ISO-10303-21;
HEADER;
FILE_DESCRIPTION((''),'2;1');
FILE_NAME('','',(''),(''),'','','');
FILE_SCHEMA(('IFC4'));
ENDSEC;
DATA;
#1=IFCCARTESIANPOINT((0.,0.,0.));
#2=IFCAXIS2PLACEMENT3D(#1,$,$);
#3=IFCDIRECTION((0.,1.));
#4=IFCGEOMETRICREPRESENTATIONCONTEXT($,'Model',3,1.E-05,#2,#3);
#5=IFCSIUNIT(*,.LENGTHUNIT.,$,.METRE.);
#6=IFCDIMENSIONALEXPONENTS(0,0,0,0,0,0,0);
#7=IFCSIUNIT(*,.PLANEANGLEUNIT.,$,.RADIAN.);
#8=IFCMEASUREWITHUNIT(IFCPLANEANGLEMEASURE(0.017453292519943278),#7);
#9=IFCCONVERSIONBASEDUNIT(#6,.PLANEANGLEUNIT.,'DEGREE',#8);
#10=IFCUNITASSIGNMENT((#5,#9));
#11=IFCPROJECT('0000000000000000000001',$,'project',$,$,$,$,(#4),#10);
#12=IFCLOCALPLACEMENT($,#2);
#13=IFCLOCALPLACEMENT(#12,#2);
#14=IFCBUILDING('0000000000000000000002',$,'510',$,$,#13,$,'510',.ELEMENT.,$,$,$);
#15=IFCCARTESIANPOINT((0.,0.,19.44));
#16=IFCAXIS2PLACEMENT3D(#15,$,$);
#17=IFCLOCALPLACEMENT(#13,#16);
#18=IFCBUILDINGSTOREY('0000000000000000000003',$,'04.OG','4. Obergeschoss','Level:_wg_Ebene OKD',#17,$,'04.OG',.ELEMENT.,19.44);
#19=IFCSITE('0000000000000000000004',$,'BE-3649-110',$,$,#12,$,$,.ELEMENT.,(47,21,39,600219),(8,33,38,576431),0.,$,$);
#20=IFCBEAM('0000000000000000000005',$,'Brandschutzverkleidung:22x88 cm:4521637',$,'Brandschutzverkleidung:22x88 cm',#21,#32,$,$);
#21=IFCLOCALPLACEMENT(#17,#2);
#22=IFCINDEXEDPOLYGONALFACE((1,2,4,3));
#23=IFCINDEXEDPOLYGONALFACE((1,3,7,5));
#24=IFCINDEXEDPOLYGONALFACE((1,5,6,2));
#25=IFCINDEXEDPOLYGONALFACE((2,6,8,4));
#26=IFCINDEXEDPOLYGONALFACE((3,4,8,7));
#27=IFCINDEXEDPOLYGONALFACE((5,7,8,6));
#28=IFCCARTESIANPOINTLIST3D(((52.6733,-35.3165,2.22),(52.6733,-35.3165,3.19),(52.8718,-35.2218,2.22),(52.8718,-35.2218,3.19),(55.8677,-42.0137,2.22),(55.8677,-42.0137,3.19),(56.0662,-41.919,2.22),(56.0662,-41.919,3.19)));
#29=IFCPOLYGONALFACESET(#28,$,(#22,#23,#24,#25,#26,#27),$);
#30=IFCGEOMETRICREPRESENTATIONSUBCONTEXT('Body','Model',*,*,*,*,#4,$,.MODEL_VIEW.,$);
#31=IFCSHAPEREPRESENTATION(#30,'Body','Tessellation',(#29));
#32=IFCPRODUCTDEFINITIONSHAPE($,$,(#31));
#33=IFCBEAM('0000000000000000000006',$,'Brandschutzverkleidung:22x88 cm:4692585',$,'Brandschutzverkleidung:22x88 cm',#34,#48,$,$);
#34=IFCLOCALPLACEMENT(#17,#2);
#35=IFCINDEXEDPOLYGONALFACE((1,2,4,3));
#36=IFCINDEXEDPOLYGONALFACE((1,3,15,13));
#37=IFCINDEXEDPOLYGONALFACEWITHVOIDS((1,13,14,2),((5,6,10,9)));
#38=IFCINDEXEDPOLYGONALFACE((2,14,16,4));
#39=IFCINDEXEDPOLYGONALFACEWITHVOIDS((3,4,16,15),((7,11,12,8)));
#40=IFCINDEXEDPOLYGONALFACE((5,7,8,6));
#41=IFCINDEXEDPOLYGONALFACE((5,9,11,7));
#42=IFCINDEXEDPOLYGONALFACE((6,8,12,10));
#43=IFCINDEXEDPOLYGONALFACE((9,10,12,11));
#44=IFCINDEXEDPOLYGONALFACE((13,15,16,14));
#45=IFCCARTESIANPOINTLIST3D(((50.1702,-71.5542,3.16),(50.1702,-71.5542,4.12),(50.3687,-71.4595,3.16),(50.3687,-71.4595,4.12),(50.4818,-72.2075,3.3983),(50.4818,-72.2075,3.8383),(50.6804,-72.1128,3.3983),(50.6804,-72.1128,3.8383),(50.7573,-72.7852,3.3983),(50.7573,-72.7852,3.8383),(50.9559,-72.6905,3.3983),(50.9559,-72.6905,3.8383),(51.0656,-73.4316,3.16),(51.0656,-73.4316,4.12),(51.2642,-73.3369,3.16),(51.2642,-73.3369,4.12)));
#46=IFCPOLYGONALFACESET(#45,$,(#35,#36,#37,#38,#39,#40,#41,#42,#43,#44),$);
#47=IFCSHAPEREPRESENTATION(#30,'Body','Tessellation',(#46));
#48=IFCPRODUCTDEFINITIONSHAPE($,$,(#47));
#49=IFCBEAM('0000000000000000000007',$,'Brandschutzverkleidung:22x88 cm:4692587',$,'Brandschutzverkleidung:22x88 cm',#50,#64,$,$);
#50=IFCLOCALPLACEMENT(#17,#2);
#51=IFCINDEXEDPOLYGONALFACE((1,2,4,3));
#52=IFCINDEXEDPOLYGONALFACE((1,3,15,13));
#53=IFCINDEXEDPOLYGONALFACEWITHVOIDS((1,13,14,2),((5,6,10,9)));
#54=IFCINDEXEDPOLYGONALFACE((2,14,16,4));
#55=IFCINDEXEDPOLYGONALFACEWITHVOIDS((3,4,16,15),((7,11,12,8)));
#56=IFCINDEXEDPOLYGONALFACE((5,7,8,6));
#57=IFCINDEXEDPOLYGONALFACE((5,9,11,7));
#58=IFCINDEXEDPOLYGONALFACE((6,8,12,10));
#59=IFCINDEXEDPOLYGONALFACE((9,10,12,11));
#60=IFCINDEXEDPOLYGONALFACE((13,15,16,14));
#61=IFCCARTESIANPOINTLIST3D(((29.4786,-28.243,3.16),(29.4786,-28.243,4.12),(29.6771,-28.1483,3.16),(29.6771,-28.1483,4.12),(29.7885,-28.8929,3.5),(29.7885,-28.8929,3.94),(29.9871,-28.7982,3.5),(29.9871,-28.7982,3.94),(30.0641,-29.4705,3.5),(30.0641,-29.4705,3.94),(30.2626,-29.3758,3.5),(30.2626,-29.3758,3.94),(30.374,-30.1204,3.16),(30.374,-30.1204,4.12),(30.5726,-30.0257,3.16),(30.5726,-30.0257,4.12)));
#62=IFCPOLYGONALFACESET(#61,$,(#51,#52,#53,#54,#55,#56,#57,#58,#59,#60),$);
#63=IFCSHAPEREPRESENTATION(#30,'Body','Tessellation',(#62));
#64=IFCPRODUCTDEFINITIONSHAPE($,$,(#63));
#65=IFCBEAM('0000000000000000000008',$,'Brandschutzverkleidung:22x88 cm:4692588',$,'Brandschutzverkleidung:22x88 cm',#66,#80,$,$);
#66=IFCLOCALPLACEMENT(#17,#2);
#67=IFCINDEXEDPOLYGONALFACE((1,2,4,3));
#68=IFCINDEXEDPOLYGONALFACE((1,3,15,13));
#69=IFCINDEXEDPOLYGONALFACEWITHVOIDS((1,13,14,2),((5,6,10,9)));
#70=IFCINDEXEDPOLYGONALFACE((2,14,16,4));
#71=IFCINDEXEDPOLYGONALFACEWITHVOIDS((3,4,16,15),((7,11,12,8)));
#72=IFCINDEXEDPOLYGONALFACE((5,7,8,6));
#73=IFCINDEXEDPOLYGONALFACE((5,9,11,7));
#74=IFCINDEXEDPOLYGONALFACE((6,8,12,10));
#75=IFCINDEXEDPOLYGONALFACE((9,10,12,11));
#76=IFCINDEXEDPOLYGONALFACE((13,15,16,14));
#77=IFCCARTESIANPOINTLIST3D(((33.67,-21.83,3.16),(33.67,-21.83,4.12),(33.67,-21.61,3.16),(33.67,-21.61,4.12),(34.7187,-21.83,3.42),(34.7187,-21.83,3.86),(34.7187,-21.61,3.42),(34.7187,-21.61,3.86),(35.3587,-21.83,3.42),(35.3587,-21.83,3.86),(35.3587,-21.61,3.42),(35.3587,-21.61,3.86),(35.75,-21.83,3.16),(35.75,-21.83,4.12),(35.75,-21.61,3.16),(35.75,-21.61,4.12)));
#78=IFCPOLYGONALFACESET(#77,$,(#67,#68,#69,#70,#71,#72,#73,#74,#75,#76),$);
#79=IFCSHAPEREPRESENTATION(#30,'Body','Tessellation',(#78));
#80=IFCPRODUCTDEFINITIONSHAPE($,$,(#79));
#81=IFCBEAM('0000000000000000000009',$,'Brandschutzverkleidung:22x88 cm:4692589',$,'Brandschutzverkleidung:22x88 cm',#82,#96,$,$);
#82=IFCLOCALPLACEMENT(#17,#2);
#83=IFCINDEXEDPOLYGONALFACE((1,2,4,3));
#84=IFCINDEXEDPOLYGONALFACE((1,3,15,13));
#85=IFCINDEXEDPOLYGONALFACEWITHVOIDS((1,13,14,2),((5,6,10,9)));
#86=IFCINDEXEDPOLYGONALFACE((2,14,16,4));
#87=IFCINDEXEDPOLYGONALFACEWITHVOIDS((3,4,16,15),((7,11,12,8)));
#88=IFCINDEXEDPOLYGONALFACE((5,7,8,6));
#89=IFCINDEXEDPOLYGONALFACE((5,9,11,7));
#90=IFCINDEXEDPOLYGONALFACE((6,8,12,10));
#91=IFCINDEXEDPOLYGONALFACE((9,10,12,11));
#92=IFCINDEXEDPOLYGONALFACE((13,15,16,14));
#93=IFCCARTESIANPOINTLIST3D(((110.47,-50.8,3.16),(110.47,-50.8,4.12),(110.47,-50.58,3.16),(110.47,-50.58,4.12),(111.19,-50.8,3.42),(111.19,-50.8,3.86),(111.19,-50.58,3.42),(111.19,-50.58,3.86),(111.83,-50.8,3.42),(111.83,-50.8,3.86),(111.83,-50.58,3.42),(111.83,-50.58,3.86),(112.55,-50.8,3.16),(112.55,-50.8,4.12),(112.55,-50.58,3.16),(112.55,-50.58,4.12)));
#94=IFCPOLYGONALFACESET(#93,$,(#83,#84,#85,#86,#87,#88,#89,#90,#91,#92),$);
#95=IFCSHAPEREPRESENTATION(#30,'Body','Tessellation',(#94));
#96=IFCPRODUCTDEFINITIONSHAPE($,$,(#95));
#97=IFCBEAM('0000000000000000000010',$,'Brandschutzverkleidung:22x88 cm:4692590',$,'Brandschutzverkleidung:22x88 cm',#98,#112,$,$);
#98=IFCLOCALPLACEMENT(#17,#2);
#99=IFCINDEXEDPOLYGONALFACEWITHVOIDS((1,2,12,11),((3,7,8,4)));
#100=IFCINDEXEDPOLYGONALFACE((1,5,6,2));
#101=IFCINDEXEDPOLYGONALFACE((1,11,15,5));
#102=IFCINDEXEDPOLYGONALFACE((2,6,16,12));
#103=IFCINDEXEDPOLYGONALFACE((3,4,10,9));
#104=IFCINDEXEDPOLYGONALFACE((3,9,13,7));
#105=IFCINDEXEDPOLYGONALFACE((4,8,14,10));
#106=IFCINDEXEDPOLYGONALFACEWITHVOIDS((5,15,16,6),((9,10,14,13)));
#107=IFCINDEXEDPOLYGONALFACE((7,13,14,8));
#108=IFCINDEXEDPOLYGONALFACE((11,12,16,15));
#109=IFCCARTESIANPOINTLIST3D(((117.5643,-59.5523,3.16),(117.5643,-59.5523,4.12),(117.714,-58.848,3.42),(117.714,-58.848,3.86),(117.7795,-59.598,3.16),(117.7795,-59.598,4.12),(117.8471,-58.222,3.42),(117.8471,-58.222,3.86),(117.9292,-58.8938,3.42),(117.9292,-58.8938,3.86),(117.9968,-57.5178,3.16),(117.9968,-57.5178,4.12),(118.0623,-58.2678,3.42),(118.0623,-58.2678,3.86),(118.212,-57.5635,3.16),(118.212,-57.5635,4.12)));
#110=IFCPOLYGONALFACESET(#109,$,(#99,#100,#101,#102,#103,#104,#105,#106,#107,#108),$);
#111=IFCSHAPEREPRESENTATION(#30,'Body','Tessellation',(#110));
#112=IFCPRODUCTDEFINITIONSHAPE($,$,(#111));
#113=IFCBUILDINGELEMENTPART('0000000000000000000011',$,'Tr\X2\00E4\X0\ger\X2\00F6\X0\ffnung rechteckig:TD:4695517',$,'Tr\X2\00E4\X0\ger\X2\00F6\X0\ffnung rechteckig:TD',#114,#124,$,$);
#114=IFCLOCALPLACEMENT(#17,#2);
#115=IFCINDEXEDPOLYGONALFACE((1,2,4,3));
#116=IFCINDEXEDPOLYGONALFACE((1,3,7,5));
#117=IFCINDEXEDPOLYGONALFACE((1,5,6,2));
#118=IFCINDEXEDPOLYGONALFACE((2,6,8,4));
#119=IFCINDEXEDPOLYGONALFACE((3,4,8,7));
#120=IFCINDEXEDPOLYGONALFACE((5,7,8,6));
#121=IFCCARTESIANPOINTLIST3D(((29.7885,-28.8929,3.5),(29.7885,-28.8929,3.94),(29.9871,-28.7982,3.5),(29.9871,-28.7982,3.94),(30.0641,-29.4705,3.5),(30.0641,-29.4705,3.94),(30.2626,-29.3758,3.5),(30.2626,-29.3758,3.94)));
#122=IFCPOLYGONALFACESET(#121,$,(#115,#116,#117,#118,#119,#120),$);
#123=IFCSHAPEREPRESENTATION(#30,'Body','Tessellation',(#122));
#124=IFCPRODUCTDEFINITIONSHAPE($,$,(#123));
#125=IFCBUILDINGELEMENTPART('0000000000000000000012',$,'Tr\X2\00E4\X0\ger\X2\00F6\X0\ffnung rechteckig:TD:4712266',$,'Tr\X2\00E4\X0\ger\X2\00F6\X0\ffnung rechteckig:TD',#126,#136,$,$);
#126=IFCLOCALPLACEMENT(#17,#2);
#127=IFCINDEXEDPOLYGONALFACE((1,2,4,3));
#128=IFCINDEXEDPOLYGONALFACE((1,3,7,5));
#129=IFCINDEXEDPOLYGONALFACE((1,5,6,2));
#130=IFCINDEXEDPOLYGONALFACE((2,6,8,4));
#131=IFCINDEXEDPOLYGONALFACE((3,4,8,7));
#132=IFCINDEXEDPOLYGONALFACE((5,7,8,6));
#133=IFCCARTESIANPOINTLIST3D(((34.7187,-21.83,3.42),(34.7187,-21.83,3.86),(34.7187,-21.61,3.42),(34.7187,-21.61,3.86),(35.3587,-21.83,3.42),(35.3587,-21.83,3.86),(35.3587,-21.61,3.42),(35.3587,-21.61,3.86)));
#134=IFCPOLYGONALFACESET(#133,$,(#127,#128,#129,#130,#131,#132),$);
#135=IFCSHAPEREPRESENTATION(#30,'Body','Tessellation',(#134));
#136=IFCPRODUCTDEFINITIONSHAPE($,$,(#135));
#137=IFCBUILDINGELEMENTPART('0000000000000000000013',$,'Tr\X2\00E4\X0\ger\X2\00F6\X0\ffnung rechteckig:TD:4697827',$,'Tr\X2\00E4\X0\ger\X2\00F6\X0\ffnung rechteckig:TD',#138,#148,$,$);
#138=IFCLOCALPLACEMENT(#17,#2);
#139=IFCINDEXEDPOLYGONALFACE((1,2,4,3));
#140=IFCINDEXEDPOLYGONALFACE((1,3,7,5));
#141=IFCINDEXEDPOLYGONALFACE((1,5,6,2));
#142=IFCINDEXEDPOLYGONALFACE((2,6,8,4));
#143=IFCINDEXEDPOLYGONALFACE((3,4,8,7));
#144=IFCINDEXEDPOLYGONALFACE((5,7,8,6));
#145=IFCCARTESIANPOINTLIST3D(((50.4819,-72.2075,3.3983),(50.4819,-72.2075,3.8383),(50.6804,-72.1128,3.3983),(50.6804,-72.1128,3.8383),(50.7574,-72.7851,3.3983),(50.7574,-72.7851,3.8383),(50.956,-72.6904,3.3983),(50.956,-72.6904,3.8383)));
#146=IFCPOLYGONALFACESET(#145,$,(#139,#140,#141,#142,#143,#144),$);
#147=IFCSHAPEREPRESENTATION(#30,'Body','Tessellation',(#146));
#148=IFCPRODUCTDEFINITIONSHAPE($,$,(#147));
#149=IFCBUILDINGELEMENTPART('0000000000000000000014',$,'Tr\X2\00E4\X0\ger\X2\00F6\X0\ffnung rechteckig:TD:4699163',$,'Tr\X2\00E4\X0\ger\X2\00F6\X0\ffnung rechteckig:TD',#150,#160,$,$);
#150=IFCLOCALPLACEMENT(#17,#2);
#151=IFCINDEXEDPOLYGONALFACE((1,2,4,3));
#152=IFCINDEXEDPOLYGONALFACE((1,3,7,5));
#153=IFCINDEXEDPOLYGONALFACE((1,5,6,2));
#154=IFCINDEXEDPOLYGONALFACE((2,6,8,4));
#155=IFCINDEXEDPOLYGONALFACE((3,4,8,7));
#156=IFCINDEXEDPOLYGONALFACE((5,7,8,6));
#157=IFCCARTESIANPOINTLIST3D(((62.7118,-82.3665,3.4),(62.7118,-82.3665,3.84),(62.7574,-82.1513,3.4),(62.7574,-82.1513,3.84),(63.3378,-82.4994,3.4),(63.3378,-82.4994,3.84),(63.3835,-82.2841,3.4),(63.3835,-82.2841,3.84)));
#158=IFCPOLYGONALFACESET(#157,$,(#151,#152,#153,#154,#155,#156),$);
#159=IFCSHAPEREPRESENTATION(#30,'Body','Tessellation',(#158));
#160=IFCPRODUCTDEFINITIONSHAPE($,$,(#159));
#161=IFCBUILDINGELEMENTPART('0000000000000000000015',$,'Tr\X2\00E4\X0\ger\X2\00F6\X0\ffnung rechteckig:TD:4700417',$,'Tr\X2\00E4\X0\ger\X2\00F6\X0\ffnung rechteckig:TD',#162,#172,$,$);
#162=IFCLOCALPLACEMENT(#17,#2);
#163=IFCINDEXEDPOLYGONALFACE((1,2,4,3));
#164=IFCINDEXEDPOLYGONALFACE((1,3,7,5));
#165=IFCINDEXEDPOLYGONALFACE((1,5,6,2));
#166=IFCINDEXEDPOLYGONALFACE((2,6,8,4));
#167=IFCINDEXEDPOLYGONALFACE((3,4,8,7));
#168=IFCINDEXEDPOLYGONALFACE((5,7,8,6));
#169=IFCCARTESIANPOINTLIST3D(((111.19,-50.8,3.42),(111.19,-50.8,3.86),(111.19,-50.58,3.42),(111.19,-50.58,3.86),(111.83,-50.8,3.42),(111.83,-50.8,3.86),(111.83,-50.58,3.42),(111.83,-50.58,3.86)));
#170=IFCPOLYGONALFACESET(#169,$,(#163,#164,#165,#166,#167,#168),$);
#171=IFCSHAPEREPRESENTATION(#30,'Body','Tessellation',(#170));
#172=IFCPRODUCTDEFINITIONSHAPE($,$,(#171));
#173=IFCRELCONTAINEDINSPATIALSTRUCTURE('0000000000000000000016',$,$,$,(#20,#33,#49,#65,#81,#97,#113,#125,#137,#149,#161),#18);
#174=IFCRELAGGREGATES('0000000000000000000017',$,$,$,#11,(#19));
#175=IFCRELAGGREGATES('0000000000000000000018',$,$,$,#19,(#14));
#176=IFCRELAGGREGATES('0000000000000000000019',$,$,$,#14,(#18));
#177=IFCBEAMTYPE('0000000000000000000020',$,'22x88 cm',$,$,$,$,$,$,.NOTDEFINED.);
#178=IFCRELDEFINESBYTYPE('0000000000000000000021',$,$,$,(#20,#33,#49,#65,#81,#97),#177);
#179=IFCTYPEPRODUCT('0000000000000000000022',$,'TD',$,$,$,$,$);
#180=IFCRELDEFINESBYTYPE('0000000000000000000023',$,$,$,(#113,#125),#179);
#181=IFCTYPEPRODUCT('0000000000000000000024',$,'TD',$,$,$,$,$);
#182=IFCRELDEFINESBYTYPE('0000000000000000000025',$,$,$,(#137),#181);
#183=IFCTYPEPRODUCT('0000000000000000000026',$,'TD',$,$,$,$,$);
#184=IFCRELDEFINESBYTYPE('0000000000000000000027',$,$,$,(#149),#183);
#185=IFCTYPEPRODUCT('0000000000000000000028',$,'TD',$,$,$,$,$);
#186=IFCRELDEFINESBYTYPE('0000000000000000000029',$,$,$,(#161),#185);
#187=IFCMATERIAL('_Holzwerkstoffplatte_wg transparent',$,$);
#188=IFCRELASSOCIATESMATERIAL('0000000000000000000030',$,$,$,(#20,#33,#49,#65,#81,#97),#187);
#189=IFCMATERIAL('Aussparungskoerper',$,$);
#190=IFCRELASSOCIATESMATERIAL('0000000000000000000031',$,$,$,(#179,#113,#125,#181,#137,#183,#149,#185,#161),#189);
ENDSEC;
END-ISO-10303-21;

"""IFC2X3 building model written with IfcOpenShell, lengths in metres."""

from ifc_helpers import new_model, entity, si_unit, converted_unit, direction, frame, frame_2d, origin, origin_2d_with_axis, place, context, subcontext, project, spatial, polyline, rectangle, outline, extrude, source, transform, mapped, material, type_object, type_shapes, element, save


model = new_model("IFC2X3")

# Units and contexts
model_context = context("Model", 3, precision=1e-05, world=origin(), true_north=direction((0.0, 1.0)))
body_context = subcontext(model_context, "Body", "Model", "MODEL_VIEW")
ifc_project = project(units=[si_unit("LENGTHUNIT", "METRE"), converted_unit("PLANEANGLEUNIT", "DEGREE", entity("IfcPlaneAngleMeasure", 0.017453292519943278), si_unit("PLANEANGLEUNIT", "RADIAN"), dimensions=[0, 0, 0, 0, 0, 0, 0])], contexts=[model_context])

# Site, building, storey
site_placement = place(None, origin())
site = spatial("IfcSite", under=ifc_project, at=site_placement, Name="BE-3649-110", CompositionType="ELEMENT", RefLatitude=(47, 21, 39, 600219), RefLongitude=(8, 33, 38, 576431), RefElevation=0.0)
building_placement = place(site_placement, origin())
building = spatial("IfcBuilding", under=site, at=building_placement, Name="510", LongName="510", CompositionType="ELEMENT")
storey_placement = place(building_placement, frame((0.0, 0.0, 19.44)))
storey = spatial("IfcBuildingStorey", under=building, at=storey_placement, Name="04.OG", Description="4. Obergeschoss", ObjectType="Level:_wg_Ebene OKD", LongName="04.OG", CompositionType="ELEMENT", Elevation=19.44)

# Beams
ifc_material_1 = material(Name="_Holzwerkstoffplatte_wg transparent")
beam_type_1 = type_object("IfcBeamType", Name="22x88 cm", PredefinedType="NOTDEFINED")
beam_1_placement = place(storey_placement, frame((0.0, 0.0, 2.705)))
element("IfcBeam", 1, at=beam_1_placement, inside=storey, type_object=beam_type_1, material=ifc_material_1, Name="Brandschutzverkleidung:22x88 cm:4521637", ObjectType="Brandschutzverkleidung:22x88 cm", context=body_context, shape_type="SweptSolid", body=[
    extrude(rectangle(XDim=0.97, YDim=0.22, at=frame_2d((0.0, 0.1517), x_axis=(0.0, 1.0))), frame((55.967, -41.9663, 0.1517), z_axis=(-0.430511, 0.902585, 0.0), x_axis=(0.902585, 0.430511, 0.0)), (0.0, 0.0, 1.0), 7.42),
])
beam_2_placement = place(storey_placement, frame((0.0, 0.0, 3.64)))
element("IfcBeam", 2, at=beam_2_placement, inside=storey, type_object=beam_type_1, material=ifc_material_1, Name="Brandschutzverkleidung:22x88 cm:4692585", ObjectType="Brandschutzverkleidung:22x88 cm", context=body_context, shape_type="SweptSolid", body=[
    extrude(outline(polyline([(-1.04, -0.48), (1.04, -0.48), (1.04, 0.48), (-1.04, 0.48), (-1.04, -0.48)]), holes=[polyline([(0.3238, 0.2417), (0.3238, -0.1983), (-0.3162, -0.1983), (-0.3162, 0.2417), (0.3238, 0.2417)])]), frame((50.6179, -72.4929, 0.0), z_axis=(0.902585, 0.430511, 0.0), x_axis=(0.430511, -0.902585, 0.0)), (0.0, 0.0, 1.0), 0.22),
])
beam_3_placement = place(storey_placement, frame((0.0, 0.0, 3.64)))
element("IfcBeam", 3, at=beam_3_placement, inside=storey, type_object=beam_type_1, material=ifc_material_1, Name="Brandschutzverkleidung:22x88 cm:4692587", ObjectType="Brandschutzverkleidung:22x88 cm", context=body_context, shape_type="SweptSolid", body=[
    extrude(outline(polyline([(-1.04, -0.48), (1.04, -0.48), (1.04, 0.48), (-1.04, 0.48), (-1.04, -0.48)]), holes=[polyline([(-0.32, -0.14), (-0.32, 0.3), (0.32, 0.3), (0.32, -0.14), (-0.32, -0.14)])]), frame((29.9263, -29.1817, 0.0), z_axis=(0.902585, 0.430511, 0.0), x_axis=(-0.430511, 0.902585, 0.0)), (0.0, 0.0, 1.0), 0.22),
])
beam_4_placement = place(storey_placement, frame((0.0, 0.0, 3.64)))
element("IfcBeam", 4, at=beam_4_placement, inside=storey, type_object=beam_type_1, material=ifc_material_1, Name="Brandschutzverkleidung:22x88 cm:4692588", ObjectType="Brandschutzverkleidung:22x88 cm", context=body_context, shape_type="SweptSolid", body=[
    extrude(outline(polyline([(-1.04, -0.48), (1.04, -0.48), (1.04, 0.48), (-1.04, 0.48), (-1.04, -0.48)]), holes=[polyline([(0.6487, 0.22), (0.6487, -0.22), (0.0087, -0.22), (0.0087, 0.22), (0.6487, 0.22)])]), frame((34.71, -21.83, 0.0), z_axis=(0.0, 1.0, 0.0), x_axis=(1.0, 0.0, 0.0)), (0.0, 0.0, 1.0), 0.22),
])
beam_5_placement = place(storey_placement, frame((0.0, 0.0, 3.64)))
element("IfcBeam", 5, at=beam_5_placement, inside=storey, type_object=beam_type_1, material=ifc_material_1, Name="Brandschutzverkleidung:22x88 cm:4692589", ObjectType="Brandschutzverkleidung:22x88 cm", context=body_context, shape_type="SweptSolid", body=[
    extrude(outline(polyline([(-1.04, -0.48), (1.04, -0.48), (1.04, 0.48), (-1.04, 0.48), (-1.04, -0.48)]), holes=[polyline([(0.32, 0.22), (0.32, -0.22), (-0.32, -0.22), (-0.32, 0.22), (0.32, 0.22)])]), frame((111.51, -50.8, 0.0), z_axis=(0.0, 1.0, 0.0), x_axis=(1.0, 0.0, 0.0)), (0.0, 0.0, 1.0), 0.22),
])
beam_6_placement = place(storey_placement, frame((0.0, 0.0, 3.64)))
element("IfcBeam", 6, at=beam_6_placement, inside=storey, type_object=beam_type_1, material=ifc_material_1, Name="Brandschutzverkleidung:22x88 cm:4692590", ObjectType="Brandschutzverkleidung:22x88 cm", context=body_context, shape_type="SweptSolid", body=[
    extrude(outline(polyline([(-1.04, -0.48), (1.04, -0.48), (1.04, 0.48), (-1.04, 0.48), (-1.04, -0.48)]), holes=[polyline([(0.32, 0.22), (0.32, -0.22), (-0.32, -0.22), (-0.32, 0.22), (0.32, 0.22)])]), frame((117.7806, -58.535, 0.0), z_axis=(0.978148, -0.207912, 0.0), x_axis=(-0.207912, -0.978148, 0.0)), (0.0, 0.0, 1.0), 0.22),
])

# Building element parts
ifc_material_2 = material(Name="Aussparungskoerper")
type_product_1 = type_object("IfcTypeProduct", Name="TD", material=ifc_material_2)
shared_shape_1 = source(origin(), body_context, "Body", "SweptSolid", [
    extrude(rectangle(XDim=0.44, YDim=0.64, at=origin_2d_with_axis()), frame((0.0, 0.0, -0.22), z_axis=(0.0, 0.0, 1.0), x_axis=(0.0, 1.0, 0.0)), (0.0, 0.0, 1.0), 0.22),
])
type_shapes(type_product_1, [shared_shape_1])
for number, where, z_axis, x_axis, name in (
    (7, (30.1249, -29.087, 3.72), (0.902585, 0.430511, 0.0), (-0.430511, 0.902585, 0.0), "Trägeröffnung rechteckig:TD:4695517"),
    (8, (35.0387, -21.83, 3.64), (0.0, -1.0, 0.0), (1.0, 0.0, 0.0), "Trägeröffnung rechteckig:TD:4712266"),
):
    element("IfcBuildingElementPart", number, at=place(storey_placement, frame(where, z_axis=z_axis, x_axis=x_axis)), inside=storey, type_object=type_product_1, material=ifc_material_2, Name=name, ObjectType="Trägeröffnung rechteckig:TD", context=body_context, shape_type="MappedRepresentation", body=[
        mapped(shared_shape_1, transform((0.0, 0.0, 0.0), scale=1.0)),
    ])
type_product_2 = type_object("IfcTypeProduct", Name="TD", material=ifc_material_2)
shared_shape_2 = source(origin(), body_context, "Body", "SweptSolid", [
    extrude(rectangle(XDim=0.22, YDim=0.64, at=frame_2d((0.0, 0.0), x_axis=(1.0, 0.0))), frame((50.7189, -72.449, -0.44), z_axis=(0.0, 0.0, 1.0), x_axis=(0.902586, 0.43051, 0.0)), (0.0, 0.0, 1.0), 0.44),
])
type_shapes(type_product_2, [shared_shape_2])
building_element_part_1_placement = place(storey_placement, frame((0.0, 0.0, 3.8383)))
element("IfcBuildingElementPart", 9, at=building_element_part_1_placement, inside=storey, type_object=type_product_2, material=ifc_material_2, Name="Trägeröffnung rechteckig:TD:4697827", ObjectType="Trägeröffnung rechteckig:TD", context=body_context, shape_type="MappedRepresentation", body=[
    mapped(shared_shape_2, transform((0.0, 0.0, 0.0), scale=1.0)),
])
type_product_3 = type_object("IfcTypeProduct", Name="TD", material=ifc_material_2)
shared_shape_3 = source(origin(), body_context, "Body", "SweptSolid", [
    extrude(rectangle(XDim=0.44, YDim=0.64, at=origin_2d_with_axis()), frame((0.0, 0.0, -0.22), z_axis=(0.0, 0.0, 1.0), x_axis=(0.0, 1.0, 0.0)), (0.0, 0.0, 1.0), 0.22),
])
type_shapes(type_product_3, [shared_shape_3])
building_element_part_2_placement = place(storey_placement, frame((63.0248, -82.4329, 3.62), z_axis=(-0.207566, -0.978221, 0.0), x_axis=(0.978221, -0.207566, 0.0)))
element("IfcBuildingElementPart", 10, at=building_element_part_2_placement, inside=storey, type_object=type_product_3, material=ifc_material_2, Name="Trägeröffnung rechteckig:TD:4699163", ObjectType="Trägeröffnung rechteckig:TD", context=body_context, shape_type="MappedRepresentation", body=[
    mapped(shared_shape_3, transform((0.0, 0.0, 0.0), scale=1.0)),
])
type_product_4 = type_object("IfcTypeProduct", Name="TD", material=ifc_material_2)
shared_shape_4 = source(origin(), body_context, "Body", "SweptSolid", [
    extrude(rectangle(XDim=0.22, YDim=0.64, at=frame_2d((0.0, 0.0), x_axis=(1.0, 0.0))), frame((111.51, -50.69, -0.44), z_axis=(0.0, 0.0, 1.0), x_axis=(0.0, 1.0, 0.0)), (0.0, 0.0, 1.0), 0.44),
])
type_shapes(type_product_4, [shared_shape_4])
building_element_part_3_placement = place(storey_placement, frame((0.0, 0.0, 3.86)))
element("IfcBuildingElementPart", 11, at=building_element_part_3_placement, inside=storey, type_object=type_product_4, material=ifc_material_2, Name="Trägeröffnung rechteckig:TD:4700417", ObjectType="Trägeröffnung rechteckig:TD", context=body_context, shape_type="MappedRepresentation", body=[
    mapped(shared_shape_4, transform((0.0, 0.0, 0.0), scale=1.0)),
])

save(model, "model.ifc")
